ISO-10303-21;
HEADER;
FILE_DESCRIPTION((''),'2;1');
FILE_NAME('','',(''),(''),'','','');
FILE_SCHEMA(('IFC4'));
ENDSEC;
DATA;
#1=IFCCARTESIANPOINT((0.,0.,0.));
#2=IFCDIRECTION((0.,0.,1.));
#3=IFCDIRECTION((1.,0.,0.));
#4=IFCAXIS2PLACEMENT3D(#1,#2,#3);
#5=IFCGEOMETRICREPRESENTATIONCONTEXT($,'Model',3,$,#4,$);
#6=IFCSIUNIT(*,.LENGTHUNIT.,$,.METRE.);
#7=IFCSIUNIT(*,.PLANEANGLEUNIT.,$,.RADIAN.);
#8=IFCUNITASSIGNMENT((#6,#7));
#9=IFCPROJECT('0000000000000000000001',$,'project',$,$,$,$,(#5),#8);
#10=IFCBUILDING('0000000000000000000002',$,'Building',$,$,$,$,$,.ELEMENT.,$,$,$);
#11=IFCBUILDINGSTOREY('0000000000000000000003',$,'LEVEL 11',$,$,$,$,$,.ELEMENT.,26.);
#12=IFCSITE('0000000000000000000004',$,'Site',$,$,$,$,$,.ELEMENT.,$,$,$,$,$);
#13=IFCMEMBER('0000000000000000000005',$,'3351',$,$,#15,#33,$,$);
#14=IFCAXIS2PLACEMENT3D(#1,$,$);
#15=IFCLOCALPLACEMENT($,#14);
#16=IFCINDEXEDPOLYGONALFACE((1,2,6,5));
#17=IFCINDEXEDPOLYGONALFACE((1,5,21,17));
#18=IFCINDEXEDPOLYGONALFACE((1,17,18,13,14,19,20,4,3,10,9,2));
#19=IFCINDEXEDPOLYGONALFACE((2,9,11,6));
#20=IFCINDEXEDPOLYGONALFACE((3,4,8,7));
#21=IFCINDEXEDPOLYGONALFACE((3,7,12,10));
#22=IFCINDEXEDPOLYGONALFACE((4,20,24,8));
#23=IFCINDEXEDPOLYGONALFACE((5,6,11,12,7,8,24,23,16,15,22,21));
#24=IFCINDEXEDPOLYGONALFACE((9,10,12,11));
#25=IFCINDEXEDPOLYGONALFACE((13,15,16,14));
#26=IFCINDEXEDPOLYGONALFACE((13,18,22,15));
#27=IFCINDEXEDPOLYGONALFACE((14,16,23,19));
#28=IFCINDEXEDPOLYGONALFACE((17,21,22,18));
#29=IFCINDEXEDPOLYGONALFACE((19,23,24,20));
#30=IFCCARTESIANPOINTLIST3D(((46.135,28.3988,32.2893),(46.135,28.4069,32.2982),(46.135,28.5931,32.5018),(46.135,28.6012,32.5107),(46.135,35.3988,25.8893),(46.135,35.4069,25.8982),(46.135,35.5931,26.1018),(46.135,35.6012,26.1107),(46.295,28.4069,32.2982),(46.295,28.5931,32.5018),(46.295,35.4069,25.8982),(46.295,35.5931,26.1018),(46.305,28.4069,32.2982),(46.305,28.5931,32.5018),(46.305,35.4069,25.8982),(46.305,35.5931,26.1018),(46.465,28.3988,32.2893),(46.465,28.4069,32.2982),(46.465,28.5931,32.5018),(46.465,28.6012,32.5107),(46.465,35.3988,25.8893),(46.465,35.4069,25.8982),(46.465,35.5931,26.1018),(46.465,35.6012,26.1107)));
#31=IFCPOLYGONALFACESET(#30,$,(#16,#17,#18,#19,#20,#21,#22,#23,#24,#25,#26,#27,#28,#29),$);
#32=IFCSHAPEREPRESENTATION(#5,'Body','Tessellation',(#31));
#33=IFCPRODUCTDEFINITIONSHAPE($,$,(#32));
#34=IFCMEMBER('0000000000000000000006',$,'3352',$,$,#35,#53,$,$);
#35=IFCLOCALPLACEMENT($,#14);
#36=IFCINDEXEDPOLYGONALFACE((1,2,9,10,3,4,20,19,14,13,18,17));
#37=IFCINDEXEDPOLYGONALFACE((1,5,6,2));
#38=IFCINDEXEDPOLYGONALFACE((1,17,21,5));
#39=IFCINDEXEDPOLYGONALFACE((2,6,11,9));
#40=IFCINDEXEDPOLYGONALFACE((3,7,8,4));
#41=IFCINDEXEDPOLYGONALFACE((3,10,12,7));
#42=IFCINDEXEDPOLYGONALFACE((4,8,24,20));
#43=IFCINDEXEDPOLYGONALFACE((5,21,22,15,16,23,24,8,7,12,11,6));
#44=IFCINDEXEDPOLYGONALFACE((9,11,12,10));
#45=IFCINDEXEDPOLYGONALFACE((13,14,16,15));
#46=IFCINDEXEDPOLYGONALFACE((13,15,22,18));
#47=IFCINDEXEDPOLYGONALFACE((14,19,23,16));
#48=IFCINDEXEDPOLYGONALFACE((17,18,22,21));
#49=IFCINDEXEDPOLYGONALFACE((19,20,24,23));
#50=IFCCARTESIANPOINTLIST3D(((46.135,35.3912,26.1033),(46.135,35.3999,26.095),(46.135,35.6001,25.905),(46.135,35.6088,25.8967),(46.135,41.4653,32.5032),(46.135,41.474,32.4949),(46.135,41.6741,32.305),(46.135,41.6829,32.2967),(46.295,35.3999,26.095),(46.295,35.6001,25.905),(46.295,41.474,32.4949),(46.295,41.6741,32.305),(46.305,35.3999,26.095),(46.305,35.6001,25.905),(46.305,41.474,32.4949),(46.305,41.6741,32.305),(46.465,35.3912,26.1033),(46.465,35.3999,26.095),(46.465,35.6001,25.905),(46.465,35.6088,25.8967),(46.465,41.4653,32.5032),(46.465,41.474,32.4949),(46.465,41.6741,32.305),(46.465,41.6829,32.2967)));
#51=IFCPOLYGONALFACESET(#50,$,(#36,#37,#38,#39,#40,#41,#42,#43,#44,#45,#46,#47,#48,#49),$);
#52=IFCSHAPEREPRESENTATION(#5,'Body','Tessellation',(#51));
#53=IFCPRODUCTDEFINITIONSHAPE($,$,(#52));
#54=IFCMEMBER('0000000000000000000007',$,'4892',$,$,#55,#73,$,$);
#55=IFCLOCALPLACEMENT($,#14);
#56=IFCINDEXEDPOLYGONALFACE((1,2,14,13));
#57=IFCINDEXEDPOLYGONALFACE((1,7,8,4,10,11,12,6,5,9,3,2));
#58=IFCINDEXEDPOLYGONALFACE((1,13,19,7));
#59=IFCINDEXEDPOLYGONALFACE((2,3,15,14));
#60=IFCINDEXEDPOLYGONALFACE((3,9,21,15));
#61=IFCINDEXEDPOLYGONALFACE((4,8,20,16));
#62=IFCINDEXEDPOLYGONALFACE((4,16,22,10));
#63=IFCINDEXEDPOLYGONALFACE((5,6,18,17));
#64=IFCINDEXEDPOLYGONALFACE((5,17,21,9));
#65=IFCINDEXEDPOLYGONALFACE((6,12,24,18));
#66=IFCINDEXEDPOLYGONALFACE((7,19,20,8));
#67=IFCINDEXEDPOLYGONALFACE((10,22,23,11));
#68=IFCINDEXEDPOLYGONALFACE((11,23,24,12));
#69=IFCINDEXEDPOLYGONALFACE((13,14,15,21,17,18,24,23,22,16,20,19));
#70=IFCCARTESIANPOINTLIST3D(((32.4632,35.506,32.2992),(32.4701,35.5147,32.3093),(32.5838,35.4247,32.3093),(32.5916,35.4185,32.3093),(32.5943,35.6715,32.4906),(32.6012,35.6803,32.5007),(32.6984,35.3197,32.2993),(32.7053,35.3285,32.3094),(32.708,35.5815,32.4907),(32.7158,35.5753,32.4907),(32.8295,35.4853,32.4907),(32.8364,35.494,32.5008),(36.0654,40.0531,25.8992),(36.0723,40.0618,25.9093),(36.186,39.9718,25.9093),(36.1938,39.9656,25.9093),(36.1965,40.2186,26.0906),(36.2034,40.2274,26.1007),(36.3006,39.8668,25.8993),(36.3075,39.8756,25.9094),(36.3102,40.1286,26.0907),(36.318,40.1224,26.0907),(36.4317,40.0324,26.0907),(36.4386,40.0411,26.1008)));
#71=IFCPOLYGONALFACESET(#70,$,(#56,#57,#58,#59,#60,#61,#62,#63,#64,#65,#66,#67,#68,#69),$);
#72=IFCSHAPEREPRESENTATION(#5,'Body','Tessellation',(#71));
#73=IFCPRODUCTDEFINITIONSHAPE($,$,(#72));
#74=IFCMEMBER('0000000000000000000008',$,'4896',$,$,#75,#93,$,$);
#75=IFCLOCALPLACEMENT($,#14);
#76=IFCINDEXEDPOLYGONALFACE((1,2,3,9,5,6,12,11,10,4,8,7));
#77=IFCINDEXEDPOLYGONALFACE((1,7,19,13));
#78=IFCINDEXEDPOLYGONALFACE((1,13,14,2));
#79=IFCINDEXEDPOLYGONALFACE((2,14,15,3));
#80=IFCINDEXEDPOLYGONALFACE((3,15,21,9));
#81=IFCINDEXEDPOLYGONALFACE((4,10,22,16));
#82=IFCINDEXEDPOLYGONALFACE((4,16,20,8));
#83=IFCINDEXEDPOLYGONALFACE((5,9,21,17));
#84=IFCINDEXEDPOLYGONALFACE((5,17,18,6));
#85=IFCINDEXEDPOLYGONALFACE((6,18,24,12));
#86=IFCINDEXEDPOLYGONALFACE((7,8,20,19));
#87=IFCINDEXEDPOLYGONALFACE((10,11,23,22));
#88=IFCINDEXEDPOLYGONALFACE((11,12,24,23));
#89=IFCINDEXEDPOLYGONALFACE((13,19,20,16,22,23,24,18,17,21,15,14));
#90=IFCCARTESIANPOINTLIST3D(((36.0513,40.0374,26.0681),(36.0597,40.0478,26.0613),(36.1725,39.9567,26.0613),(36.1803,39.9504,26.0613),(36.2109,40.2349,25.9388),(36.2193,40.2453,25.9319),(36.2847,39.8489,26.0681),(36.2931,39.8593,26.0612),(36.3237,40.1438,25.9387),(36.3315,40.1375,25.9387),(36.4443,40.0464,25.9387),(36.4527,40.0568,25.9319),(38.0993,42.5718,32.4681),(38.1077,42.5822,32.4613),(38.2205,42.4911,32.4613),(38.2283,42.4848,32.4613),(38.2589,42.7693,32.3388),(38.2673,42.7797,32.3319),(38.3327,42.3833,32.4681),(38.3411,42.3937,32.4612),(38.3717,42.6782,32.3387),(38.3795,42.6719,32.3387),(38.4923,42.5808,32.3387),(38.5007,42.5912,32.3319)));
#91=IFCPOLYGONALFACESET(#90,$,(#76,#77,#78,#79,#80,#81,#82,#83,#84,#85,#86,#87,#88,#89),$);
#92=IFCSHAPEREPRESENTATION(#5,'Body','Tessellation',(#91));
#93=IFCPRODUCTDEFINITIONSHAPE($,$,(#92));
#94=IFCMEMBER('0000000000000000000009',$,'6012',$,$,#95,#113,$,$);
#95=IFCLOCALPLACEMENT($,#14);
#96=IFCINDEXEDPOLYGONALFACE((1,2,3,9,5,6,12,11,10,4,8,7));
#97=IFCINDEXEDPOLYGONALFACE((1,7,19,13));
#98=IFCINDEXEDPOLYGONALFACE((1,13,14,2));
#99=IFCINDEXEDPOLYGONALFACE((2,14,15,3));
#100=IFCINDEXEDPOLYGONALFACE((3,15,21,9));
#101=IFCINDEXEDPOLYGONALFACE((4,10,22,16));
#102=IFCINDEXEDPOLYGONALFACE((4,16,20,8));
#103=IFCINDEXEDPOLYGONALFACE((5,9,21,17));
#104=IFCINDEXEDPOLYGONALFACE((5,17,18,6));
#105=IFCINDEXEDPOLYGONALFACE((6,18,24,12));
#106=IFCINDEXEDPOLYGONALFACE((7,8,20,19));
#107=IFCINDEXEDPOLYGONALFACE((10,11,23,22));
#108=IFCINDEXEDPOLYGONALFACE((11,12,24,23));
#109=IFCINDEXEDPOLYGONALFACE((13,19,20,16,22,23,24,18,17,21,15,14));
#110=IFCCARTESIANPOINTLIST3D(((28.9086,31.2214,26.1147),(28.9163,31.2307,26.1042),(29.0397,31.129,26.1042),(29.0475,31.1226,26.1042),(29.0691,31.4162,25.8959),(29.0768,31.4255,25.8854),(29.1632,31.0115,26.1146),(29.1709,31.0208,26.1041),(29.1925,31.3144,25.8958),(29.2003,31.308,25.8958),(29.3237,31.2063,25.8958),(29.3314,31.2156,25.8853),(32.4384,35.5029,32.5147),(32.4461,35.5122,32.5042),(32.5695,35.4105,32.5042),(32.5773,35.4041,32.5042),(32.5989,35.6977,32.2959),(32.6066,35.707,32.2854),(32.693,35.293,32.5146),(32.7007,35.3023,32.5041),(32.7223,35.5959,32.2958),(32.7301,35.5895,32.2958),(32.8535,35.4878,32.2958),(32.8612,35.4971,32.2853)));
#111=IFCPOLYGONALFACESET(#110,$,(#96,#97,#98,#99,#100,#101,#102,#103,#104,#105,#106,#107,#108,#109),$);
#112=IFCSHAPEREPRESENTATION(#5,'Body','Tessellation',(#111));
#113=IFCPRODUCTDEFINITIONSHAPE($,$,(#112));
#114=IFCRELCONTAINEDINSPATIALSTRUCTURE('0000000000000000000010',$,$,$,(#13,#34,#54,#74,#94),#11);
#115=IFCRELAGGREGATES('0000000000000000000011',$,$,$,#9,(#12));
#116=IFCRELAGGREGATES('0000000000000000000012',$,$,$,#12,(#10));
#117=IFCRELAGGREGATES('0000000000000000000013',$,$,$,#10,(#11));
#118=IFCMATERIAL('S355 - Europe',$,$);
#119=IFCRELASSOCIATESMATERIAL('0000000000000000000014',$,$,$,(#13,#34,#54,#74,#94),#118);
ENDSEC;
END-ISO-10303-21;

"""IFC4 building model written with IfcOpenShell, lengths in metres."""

from ifc_helpers import new_model, si_unit, frame, origin_with_axes, origin_2d_with_axis, place, context, project, spatial, i_section, extrude, material, material_profile, profile_set, profile_usage, element, save


model = new_model("IFC4")

# Units and contexts
model_context = context("Model", 3, world=origin_with_axes())
ifc_project = project(units=[si_unit("LENGTHUNIT", "METRE"), si_unit("PLANEANGLEUNIT", "RADIAN")], contexts=[model_context])

# Site, building, storey
site = spatial("IfcSite", under=ifc_project, Name="Site", CompositionType="ELEMENT")
building = spatial("IfcBuilding", under=site, Name="Building", CompositionType="ELEMENT")
storey = spatial("IfcBuildingStorey", under=building, Name="LEVEL 11", CompositionType="ELEMENT", Elevation=26.0)

# Shared definitions
ifc_material = material(Name="S355 - Europe")

# Members
ifc_material_profile_1 = material_profile(ifc_material, i_section(OverallWidth=0.33, OverallDepth=0.3, WebThickness=0.01, FlangeThickness=0.012, at=origin_2d_with_axis()))
ifc_profile_set_1 = profile_set([ifc_material_profile_1])
ifc_profile_usage_1 = profile_usage(ifc_profile_set_1, cardinal=10)
member_1_placement = place(None, frame((46.3, 28.5, 32.4), z_axis=(0.0, 0.738029, -0.674769), x_axis=(-1.0, 0.0, 0.0)))
element("IfcMember", 1, at=member_1_placement, inside=storey, material=ifc_profile_usage_1, Name="3351", context=model_context, shape_type="SweptSolid", body=[
    extrude(i_section(OverallWidth=0.33, OverallDepth=0.3, WebThickness=0.01, FlangeThickness=0.012, at=origin_2d_with_axis()), origin_with_axes(), (0.0, 0.0, 1.0), 9.4847),
])
ifc_material_profile_2 = material_profile(ifc_material, i_section(OverallWidth=0.33, OverallDepth=0.3, WebThickness=0.01, FlangeThickness=0.012, at=origin_2d_with_axis()))
ifc_profile_set_2 = profile_set([ifc_material_profile_2])
ifc_profile_usage_2 = profile_usage(ifc_profile_set_2, cardinal=10)
member_2_placement = place(None, frame((46.3, 35.5, 26.0), z_axis=(0.0, 0.688398, 0.725333), x_axis=(-1.0, 0.0, 0.0)))
element("IfcMember", 2, at=member_2_placement, inside=storey, material=ifc_profile_usage_2, Name="3352", context=model_context, shape_type="SweptSolid", body=[
    extrude(i_section(OverallWidth=0.33, OverallDepth=0.3, WebThickness=0.01, FlangeThickness=0.012, at=origin_2d_with_axis()), origin_with_axes(), (0.0, 0.0, 1.0), 8.8235),
])
ifc_material_profile_3 = material_profile(ifc_material, i_section(OverallWidth=0.3, OverallDepth=0.3, WebThickness=0.01, FlangeThickness=0.015, at=origin_2d_with_axis()))
ifc_profile_set_3 = profile_set([ifc_material_profile_3])
ifc_profile_usage_3 = profile_usage(ifc_profile_set_3, cardinal=10)
member_3_placement = place(None, frame((32.6498, 35.5, 32.4), z_axis=(0.417026, 0.526417, -0.740928), x_axis=(-0.784074, 0.620667, 0.0)))
element("IfcMember", 3, at=member_3_placement, inside=storey, material=ifc_profile_usage_3, Name="4892", context=model_context, shape_type="SweptSolid", body=[
    extrude(i_section(OverallWidth=0.3, OverallDepth=0.3, WebThickness=0.01, FlangeThickness=0.015, at=origin_2d_with_axis()), origin_with_axes(), (0.0, 0.0, 1.0), 8.6378),
])
ifc_material_profile_4 = material_profile(ifc_material, i_section(OverallWidth=0.3, OverallDepth=0.3, WebThickness=0.01, FlangeThickness=0.015, at=origin_2d_with_axis()))
ifc_profile_set_4 = profile_set([ifc_material_profile_4])
ifc_profile_usage_4 = profile_usage(ifc_profile_set_4, cardinal=10)
member_4_placement = place(None, frame((36.252, 40.0471, 26.0), z_axis=(0.285167, 0.352895, 0.891148), x_axis=(-0.777826, 0.62848, 0.0)))
element("IfcMember", 4, at=member_4_placement, inside=storey, material=ifc_profile_usage_4, Name="4896", context=model_context, shape_type="SweptSolid", body=[
    extrude(i_section(OverallWidth=0.3, OverallDepth=0.3, WebThickness=0.01, FlangeThickness=0.015, at=origin_2d_with_axis()), origin_with_axes(), (0.0, 0.0, 1.0), 7.1817),
])
ifc_material_profile_5 = material_profile(ifc_material, i_section(OverallWidth=0.33, OverallDepth=0.35, WebThickness=0.01, FlangeThickness=0.016, at=origin_2d_with_axis()))
ifc_profile_set_5 = profile_set([ifc_material_profile_5])
ifc_profile_usage_5 = profile_usage(ifc_profile_set_5, cardinal=10)
member_5_placement = place(None, frame((29.12, 31.2185, 26.0), z_axis=(0.416713, 0.505455, 0.755556), x_axis=(-0.771703, 0.635983, 0.0)))
element("IfcMember", 5, at=member_5_placement, inside=storey, material=ifc_profile_usage_5, Name="6012", context=model_context, shape_type="SweptSolid", body=[
    extrude(i_section(OverallWidth=0.33, OverallDepth=0.35, WebThickness=0.01, FlangeThickness=0.016, at=origin_2d_with_axis()), origin_with_axes(), (0.0, 0.0, 1.0), 8.4706),
])

save(model, "model.ifc")
